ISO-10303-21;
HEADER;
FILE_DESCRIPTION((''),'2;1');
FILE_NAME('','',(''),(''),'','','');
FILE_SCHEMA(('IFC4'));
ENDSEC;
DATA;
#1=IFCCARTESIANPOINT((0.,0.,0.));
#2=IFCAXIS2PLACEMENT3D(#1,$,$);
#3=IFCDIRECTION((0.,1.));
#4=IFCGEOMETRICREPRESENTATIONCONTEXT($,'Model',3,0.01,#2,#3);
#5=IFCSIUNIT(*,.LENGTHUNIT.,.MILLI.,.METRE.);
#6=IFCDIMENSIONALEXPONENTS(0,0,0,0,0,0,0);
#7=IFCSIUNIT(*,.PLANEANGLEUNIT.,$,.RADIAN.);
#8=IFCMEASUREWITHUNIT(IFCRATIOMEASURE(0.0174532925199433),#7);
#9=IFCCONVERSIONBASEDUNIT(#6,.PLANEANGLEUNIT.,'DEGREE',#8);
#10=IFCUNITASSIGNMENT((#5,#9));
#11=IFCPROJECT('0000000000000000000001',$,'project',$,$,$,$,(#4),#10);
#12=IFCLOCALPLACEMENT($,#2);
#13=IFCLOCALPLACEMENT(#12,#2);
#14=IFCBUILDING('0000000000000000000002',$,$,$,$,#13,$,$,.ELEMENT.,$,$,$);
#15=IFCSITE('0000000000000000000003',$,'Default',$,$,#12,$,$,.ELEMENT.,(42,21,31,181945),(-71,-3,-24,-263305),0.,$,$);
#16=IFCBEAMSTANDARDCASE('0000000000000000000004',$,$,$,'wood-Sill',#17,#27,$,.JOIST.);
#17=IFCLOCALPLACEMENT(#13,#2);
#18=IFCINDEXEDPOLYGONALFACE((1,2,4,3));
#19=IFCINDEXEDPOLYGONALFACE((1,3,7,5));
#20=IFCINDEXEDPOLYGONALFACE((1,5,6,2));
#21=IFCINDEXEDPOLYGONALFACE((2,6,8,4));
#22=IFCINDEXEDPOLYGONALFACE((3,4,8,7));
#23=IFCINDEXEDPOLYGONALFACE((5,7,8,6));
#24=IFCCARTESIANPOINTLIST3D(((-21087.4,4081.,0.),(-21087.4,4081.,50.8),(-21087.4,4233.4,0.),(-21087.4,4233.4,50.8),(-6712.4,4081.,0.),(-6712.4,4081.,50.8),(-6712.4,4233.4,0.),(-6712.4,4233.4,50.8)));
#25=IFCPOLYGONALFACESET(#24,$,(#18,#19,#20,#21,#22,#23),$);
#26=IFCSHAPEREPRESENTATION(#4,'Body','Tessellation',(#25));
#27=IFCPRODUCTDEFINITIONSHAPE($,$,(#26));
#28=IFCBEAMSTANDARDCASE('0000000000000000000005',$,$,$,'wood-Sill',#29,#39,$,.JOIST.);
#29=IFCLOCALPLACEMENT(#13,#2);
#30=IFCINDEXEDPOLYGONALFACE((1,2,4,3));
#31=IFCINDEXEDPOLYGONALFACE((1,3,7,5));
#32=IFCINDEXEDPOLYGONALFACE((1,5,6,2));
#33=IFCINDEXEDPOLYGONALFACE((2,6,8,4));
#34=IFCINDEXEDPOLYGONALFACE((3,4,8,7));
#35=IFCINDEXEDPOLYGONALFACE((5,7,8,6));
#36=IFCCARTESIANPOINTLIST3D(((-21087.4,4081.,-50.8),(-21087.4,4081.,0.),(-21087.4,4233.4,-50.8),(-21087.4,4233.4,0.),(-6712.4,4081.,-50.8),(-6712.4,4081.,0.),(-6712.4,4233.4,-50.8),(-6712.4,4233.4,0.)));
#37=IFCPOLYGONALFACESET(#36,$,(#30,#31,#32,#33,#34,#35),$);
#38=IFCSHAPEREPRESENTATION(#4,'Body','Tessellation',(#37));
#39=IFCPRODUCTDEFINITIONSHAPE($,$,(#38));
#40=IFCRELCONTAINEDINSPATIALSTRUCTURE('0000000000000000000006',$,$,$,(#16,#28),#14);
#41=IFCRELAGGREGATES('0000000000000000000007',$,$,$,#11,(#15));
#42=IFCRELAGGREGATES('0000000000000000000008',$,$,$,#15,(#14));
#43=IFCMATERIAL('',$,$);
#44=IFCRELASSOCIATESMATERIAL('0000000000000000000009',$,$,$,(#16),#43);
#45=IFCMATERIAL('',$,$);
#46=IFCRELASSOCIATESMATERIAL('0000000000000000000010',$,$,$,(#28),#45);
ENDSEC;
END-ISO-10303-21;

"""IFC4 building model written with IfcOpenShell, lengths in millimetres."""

from ifc_helpers import new_model, entity, si_unit, converted_unit, direction, frame, origin, place, context, project, spatial, rectangle, extrude, material, element, save


model = new_model("IFC4")

# Units and contexts
model_context = context("Model", 3, precision=0.01, world=origin(), true_north=direction((0.0, 1.0)))
ifc_project = project(units=[si_unit("LENGTHUNIT", "METRE", prefix="MILLI"), converted_unit("PLANEANGLEUNIT", "DEGREE", entity("IfcRatioMeasure", 0.0174532925199433), si_unit("PLANEANGLEUNIT", "RADIAN"), dimensions=[0, 0, 0, 0, 0, 0, 0])], contexts=[model_context])

# Site, building
site_placement = place(None, origin())
site = spatial("IfcSite", under=ifc_project, at=site_placement, Name="Default", CompositionType="ELEMENT", RefLatitude=(42, 21, 31, 181945), RefLongitude=(-71, -3, -24, -263305), RefElevation=0.0)
building_placement = place(site_placement, origin())
building = spatial("IfcBuilding", under=site, at=building_placement, CompositionType="ELEMENT")

# Shared definitions
placement_1 = place(building_placement, origin())
placement_2 = place(placement_1, frame((-13899.9, 11344.7, 0.0), z_axis=(0.0, 0.0, 1.0), x_axis=(0.0, -1.0, 0.0)))

# Beams
ifc_material_1 = material(Name="")
beam_1_placement = place(placement_2, frame((7187.5, 0.0, 0.0), z_axis=(0.0, 0.0, 1.0), x_axis=(0.0, -1.0, 0.0)))
element("IfcBeamStandardCase", 1, at=beam_1_placement, inside=building, material=ifc_material_1, ObjectType="wood-Sill", PredefinedType="JOIST", context=model_context, shape_type="SweptSolid", body=[
    extrude(rectangle(XDim=14375.0, YDim=152.4), origin(), (0.0, 0.0, 1.0), 50.8),
])
ifc_material_2 = material(Name="")
beam_2_placement = place(placement_2, frame((7187.5, 0.0, -50.8), z_axis=(0.0, 0.0, 1.0), x_axis=(0.0, -1.0, 0.0)))
element("IfcBeamStandardCase", 2, at=beam_2_placement, inside=building, material=ifc_material_2, ObjectType="wood-Sill", PredefinedType="JOIST", context=model_context, shape_type="SweptSolid", body=[
    extrude(rectangle(XDim=14375.0, YDim=152.4), origin(), (0.0, 0.0, 1.0), 50.8),
])

save(model, "model.ifc")
